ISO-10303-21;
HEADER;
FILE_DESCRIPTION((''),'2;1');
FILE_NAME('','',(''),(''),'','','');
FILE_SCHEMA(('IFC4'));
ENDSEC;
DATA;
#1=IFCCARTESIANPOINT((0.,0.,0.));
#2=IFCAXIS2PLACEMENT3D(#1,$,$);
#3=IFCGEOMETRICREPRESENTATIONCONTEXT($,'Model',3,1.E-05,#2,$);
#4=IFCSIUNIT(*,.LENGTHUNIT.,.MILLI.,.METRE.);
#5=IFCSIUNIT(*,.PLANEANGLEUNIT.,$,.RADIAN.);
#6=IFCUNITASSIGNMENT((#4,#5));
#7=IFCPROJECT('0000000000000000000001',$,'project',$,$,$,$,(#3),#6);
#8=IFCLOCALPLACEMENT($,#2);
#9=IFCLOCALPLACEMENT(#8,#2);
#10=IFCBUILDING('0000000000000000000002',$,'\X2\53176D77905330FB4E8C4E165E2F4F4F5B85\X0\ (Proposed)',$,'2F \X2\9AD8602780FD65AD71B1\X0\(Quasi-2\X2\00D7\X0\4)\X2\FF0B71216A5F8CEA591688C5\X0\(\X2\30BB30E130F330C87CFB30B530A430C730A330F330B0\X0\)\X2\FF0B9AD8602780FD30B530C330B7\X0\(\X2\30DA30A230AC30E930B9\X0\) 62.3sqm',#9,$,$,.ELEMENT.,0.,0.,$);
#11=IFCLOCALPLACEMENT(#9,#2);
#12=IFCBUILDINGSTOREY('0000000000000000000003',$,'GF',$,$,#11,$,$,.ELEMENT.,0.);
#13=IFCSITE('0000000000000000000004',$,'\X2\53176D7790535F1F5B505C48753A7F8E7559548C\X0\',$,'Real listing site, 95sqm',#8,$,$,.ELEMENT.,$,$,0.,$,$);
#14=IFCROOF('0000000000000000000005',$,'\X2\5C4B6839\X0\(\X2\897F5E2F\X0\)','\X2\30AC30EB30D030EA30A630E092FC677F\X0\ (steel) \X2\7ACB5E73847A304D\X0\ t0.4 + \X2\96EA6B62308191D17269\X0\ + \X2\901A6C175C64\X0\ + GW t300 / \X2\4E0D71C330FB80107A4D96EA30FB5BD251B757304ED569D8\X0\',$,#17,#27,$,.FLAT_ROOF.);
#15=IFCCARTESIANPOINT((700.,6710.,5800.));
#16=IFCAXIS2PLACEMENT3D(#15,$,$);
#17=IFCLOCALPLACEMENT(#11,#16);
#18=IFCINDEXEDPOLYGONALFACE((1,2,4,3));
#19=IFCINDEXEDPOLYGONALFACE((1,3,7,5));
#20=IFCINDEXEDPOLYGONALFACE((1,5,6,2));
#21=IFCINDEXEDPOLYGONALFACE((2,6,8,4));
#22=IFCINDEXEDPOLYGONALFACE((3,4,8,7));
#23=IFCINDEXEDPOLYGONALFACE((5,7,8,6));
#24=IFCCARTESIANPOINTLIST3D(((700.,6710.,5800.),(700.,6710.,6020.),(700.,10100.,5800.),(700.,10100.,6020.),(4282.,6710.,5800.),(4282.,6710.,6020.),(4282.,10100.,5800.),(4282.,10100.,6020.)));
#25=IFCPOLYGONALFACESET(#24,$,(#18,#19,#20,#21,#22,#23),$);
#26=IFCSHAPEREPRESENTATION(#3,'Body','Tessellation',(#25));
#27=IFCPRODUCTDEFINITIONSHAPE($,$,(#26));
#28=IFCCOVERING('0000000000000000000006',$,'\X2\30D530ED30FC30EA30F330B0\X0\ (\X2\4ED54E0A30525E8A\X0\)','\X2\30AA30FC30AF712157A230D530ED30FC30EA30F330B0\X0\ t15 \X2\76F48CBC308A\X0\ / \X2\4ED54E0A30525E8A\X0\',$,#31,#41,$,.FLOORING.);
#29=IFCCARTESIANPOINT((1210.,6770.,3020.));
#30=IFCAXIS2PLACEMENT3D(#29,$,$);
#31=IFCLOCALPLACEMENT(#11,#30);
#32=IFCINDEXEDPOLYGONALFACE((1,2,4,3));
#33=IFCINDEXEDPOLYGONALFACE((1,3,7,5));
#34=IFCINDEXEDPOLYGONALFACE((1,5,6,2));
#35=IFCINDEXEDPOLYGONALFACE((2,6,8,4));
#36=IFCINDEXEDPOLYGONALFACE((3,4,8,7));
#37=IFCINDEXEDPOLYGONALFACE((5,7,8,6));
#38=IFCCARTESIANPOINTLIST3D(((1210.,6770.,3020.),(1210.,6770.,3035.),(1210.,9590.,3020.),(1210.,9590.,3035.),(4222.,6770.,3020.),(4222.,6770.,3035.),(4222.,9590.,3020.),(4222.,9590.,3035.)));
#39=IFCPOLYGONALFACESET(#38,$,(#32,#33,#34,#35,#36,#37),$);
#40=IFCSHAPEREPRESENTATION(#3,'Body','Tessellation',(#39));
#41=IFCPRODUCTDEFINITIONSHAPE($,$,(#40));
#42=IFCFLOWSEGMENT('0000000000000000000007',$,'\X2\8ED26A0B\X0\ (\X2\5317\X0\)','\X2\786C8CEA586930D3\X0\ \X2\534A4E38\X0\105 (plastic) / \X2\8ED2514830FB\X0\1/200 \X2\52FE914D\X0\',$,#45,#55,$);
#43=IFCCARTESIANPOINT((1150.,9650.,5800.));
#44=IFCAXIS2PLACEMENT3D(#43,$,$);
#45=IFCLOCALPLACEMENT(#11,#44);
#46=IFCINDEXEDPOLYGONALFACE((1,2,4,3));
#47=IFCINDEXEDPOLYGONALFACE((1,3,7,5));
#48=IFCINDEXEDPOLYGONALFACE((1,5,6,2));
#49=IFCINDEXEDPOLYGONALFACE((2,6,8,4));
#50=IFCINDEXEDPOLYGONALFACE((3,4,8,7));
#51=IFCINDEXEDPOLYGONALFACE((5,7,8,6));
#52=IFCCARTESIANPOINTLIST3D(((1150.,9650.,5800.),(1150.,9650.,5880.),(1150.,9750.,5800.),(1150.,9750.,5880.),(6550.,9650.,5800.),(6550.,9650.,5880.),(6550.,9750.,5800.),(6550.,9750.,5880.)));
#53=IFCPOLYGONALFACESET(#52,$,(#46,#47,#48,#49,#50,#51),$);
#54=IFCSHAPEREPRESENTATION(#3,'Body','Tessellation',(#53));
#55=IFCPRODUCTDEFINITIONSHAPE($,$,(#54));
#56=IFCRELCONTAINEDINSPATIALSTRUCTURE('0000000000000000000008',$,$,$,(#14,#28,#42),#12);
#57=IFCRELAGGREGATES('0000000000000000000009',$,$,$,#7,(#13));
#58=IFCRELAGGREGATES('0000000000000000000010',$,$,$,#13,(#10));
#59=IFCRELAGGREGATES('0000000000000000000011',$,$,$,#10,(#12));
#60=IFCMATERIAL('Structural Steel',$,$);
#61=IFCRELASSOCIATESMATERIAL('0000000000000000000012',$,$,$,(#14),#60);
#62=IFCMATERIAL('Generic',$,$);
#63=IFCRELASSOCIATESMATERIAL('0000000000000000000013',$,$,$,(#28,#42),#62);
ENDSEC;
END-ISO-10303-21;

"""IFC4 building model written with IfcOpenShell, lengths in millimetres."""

from ifc_helpers import new_model, si_unit, frame, frame_2d, origin, place, context, project, spatial, rectangle, extrude, material, element, save


model = new_model("IFC4")

# Units and contexts
model_context = context("Model", 3, precision=1e-05, world=origin())
ifc_project = project(units=[si_unit("LENGTHUNIT", "METRE", prefix="MILLI"), si_unit("PLANEANGLEUNIT", "RADIAN")], contexts=[model_context])

# Site, building, storey
site_placement = place(None, origin())
site = spatial("IfcSite", under=ifc_project, at=site_placement, Name="北海道弟子屈町美留和", ObjectType="Real listing site, 95sqm", CompositionType="ELEMENT", RefElevation=0.0)
building_placement = place(site_placement, origin())
building = spatial("IfcBuilding", under=site, at=building_placement, Name="北海道・二世帯住宅 (Proposed)", ObjectType="2F 高性能断熱(Quasi-2×4)＋無機質外装(セメント系サイディング)＋高性能サッシ(ペアガラス) 62.3sqm", CompositionType="ELEMENT", ElevationOfRefHeight=0.0, ElevationOfTerrain=0.0)
storey_placement = place(building_placement, origin())
storey = spatial("IfcBuildingStorey", under=building, at=storey_placement, Name="GF", CompositionType="ELEMENT", Elevation=0.0)

# Roof
ifc_material_1 = material(Name="Structural Steel")
for number, where, name in (
    (1, (700.0, 6710.0, 5800.0), "屋根(西帯)"),
):
    element("IfcRoof", number, at=place(storey_placement, frame(where)), inside=storey, material=ifc_material_1, Name=name, Description="ガルバリウム鋼板 (steel) 立平葺き t0.4 + 雪止め金物 + 通気層 + GW t300 / 不燃・耐積雪・寒冷地仕様", PredefinedType="FLAT_ROOF", context=model_context, shape_type="SweptSolid", body=[
        extrude(rectangle(XDim=3582.0, YDim=3390.0, at=frame_2d((1791.0, 1695.0))), frame((700.0, 6710.0, 5800.0)), (0.0, 0.0, 1.0), 220.0),
    ])

# Covering
ifc_material_2 = material(Name="Generic")
covering_placement = place(storey_placement, frame((1210.0, 6770.0, 3020.0)))
element("IfcCovering", 2, at=covering_placement, inside=storey, material=ifc_material_2, Name="フローリング (仕上げ床)", Description="オーク無垢フローリング t15 直貼り / 仕上げ床", PredefinedType="FLOORING", context=model_context, shape_type="SweptSolid", body=[
    extrude(rectangle(XDim=3012.0, YDim=2820.0, at=frame_2d((1506.0, 1410.0))), frame((1210.0, 6770.0, 3020.0)), (0.0, 0.0, 1.0), 15.0),
])

# Flow segment
flow_segment_placement = place(storey_placement, frame((1150.0, 9650.0, 5800.0)))
element("IfcFlowSegment", 3, at=flow_segment_placement, inside=storey, material=ifc_material_2, Name="軒樋 (北)", Description="硬質塩ビ 半丸105 (plastic) / 軒先・1/200 勾配", context=model_context, shape_type="SweptSolid", body=[
    extrude(rectangle(XDim=5400.0, YDim=100.0, at=frame_2d((2700.0, 50.0))), frame((1150.0, 9650.0, 5800.0)), (0.0, 0.0, 1.0), 80.0),
])

save(model, "model.ifc")
